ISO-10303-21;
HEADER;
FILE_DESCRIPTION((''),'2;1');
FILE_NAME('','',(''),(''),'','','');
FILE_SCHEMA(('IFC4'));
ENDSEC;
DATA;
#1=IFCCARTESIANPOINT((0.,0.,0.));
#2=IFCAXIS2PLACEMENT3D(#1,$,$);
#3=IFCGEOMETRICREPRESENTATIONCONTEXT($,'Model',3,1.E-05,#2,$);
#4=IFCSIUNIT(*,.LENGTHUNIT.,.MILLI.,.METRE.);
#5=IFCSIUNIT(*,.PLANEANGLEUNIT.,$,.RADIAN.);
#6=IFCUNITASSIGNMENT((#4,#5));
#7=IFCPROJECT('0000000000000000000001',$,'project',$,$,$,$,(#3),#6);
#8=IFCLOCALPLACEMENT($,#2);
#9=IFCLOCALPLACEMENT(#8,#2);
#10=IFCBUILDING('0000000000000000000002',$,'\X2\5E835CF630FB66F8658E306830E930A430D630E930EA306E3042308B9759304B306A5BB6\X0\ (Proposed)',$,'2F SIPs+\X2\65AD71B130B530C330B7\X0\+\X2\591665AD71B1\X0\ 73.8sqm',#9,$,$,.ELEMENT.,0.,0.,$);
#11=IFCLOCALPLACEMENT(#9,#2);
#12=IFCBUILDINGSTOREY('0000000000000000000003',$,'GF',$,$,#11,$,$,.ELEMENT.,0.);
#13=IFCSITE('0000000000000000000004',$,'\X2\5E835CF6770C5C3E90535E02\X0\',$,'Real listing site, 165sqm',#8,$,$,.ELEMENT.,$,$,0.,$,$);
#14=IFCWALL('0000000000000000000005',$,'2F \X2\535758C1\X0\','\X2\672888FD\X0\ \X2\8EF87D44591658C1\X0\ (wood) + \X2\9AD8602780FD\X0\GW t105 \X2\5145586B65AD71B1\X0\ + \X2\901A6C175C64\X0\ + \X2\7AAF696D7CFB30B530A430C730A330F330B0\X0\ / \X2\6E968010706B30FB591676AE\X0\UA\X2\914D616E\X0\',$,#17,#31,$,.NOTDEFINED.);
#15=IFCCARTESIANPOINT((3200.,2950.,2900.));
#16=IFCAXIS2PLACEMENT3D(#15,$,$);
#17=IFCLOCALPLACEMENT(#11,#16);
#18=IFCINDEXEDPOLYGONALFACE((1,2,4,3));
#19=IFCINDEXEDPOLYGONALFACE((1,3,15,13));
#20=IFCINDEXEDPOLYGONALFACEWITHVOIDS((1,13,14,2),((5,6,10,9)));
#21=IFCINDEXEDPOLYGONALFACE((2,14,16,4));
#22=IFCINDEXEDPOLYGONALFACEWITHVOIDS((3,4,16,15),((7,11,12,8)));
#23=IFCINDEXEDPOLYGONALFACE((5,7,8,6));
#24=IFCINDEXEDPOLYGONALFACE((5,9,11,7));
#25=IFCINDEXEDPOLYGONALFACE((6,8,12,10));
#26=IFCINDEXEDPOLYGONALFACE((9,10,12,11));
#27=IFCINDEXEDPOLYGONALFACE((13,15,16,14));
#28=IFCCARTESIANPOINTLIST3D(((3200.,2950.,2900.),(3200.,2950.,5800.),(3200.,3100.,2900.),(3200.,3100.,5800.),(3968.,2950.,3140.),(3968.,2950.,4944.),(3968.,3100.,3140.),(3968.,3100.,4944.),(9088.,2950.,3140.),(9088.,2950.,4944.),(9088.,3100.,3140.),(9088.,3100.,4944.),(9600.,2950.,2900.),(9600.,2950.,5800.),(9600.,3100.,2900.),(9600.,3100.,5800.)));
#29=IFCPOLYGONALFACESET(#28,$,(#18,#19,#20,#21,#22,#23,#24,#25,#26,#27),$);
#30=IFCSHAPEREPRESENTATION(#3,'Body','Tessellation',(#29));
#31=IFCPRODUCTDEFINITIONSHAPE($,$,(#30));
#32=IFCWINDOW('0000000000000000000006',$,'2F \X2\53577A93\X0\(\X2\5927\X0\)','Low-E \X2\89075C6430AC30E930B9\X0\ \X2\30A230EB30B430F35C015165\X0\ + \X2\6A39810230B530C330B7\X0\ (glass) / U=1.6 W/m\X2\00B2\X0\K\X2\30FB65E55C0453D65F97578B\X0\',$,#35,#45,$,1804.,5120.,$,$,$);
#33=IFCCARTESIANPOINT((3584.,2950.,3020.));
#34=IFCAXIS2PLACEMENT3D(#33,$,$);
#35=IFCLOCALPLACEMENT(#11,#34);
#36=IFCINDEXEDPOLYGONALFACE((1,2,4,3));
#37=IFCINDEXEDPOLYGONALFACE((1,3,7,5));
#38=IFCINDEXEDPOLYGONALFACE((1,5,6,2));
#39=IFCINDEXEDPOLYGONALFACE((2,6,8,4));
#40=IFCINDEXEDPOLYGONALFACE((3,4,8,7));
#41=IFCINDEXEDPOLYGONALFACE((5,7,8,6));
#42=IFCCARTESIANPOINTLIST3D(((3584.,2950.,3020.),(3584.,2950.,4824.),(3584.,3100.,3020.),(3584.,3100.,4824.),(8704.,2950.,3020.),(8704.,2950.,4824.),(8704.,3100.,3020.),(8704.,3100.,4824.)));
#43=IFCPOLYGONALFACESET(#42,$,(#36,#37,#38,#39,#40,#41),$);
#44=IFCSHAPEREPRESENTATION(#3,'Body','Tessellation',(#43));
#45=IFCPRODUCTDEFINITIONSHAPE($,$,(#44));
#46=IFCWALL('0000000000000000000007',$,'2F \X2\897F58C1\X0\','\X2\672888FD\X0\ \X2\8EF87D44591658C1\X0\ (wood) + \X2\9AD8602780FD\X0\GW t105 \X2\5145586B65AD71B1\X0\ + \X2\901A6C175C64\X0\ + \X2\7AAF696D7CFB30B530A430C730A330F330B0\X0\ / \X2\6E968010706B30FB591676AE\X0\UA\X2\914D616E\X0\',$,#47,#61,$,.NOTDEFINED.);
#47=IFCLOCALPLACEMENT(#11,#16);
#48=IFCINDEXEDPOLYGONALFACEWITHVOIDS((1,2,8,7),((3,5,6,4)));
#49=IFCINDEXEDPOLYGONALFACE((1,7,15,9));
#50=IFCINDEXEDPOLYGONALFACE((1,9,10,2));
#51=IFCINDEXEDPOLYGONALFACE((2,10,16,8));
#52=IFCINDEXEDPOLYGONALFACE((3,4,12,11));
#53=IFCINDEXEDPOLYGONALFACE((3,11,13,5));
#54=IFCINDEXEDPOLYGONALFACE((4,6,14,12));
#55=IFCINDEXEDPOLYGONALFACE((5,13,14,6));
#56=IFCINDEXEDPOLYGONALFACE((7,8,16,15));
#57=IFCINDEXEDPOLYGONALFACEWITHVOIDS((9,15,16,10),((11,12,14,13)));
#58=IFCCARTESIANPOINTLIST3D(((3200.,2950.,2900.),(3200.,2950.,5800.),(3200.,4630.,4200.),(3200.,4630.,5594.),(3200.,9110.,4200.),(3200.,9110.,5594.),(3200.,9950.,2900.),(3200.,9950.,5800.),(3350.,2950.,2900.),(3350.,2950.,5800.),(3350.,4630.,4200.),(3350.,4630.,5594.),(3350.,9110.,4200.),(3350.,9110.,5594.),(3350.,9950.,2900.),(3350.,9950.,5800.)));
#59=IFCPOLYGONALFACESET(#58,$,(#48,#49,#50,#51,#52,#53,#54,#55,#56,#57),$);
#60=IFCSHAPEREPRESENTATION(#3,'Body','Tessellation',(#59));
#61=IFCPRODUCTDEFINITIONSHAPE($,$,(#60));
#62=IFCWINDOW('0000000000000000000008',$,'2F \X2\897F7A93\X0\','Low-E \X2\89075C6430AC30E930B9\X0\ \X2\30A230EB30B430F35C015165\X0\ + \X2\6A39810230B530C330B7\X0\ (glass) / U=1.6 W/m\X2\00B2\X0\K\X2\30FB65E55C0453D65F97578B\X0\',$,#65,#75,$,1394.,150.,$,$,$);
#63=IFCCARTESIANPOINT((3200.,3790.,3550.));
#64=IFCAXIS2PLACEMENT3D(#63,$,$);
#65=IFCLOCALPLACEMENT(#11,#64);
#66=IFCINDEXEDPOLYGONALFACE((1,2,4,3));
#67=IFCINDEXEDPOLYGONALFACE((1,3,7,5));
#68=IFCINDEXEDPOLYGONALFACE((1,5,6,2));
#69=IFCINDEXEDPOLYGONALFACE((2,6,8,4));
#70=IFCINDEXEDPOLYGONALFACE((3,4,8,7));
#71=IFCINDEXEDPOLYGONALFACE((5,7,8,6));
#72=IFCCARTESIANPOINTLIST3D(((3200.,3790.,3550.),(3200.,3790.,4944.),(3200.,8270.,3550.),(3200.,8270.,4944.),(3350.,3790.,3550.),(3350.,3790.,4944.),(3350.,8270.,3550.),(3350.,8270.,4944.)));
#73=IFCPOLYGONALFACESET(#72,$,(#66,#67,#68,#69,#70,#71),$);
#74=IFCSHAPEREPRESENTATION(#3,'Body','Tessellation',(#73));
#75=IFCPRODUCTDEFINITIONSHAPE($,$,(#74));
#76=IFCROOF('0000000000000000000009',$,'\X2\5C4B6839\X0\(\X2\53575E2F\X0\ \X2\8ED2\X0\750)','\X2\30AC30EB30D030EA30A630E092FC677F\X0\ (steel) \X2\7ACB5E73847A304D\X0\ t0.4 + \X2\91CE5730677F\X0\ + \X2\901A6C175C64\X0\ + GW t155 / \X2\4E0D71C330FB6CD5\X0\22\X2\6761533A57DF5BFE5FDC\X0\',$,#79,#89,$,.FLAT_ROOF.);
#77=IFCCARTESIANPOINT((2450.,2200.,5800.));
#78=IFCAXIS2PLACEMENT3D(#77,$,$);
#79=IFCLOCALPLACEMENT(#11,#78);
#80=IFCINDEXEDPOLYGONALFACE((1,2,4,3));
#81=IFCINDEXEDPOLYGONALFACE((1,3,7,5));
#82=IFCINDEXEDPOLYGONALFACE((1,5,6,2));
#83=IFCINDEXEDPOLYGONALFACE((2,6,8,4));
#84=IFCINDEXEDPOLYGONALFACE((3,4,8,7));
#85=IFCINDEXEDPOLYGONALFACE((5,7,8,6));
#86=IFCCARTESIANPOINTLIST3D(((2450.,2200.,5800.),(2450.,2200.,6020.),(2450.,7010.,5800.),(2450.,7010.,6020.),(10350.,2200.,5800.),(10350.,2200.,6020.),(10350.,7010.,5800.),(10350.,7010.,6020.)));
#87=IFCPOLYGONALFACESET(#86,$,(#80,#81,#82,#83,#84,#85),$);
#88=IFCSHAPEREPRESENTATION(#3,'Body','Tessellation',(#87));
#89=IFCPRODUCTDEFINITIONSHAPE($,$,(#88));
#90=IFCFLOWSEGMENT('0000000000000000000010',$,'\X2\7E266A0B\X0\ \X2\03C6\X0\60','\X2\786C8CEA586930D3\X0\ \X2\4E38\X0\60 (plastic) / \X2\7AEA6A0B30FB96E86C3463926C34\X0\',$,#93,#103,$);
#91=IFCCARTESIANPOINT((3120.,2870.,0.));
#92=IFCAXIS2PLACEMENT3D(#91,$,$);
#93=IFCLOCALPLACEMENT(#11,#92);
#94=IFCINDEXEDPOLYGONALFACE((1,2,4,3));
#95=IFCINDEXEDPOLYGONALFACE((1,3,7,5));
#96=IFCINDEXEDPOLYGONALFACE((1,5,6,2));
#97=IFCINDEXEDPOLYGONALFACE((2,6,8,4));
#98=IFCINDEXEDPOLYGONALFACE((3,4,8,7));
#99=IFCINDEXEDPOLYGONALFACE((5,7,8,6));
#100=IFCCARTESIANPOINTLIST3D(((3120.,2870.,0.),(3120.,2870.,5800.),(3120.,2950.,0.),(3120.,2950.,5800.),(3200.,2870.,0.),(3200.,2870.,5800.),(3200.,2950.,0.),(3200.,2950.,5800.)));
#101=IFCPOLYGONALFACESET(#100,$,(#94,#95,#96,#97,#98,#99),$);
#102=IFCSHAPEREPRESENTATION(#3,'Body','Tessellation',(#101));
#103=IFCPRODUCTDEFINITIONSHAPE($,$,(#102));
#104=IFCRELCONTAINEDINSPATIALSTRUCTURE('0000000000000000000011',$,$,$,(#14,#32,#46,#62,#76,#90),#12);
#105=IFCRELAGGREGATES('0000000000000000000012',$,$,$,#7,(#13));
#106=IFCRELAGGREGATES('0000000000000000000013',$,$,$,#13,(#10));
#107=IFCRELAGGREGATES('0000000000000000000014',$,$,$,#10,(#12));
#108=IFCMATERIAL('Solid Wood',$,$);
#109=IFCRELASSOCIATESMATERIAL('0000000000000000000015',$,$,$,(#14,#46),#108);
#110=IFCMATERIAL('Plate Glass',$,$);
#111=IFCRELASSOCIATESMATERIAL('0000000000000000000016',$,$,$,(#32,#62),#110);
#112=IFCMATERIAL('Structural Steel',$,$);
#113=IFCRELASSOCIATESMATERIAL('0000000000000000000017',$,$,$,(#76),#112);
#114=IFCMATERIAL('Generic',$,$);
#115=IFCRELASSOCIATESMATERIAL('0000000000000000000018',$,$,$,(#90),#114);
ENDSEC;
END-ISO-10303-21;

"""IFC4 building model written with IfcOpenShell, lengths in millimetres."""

from ifc_helpers import new_model, si_unit, frame, frame_2d, origin, place, context, project, spatial, rectangle, extrude, material, element, fill, save


model = new_model("IFC4")

# Units and contexts
model_context = context("Model", 3, precision=1e-05, world=origin())
ifc_project = project(units=[si_unit("LENGTHUNIT", "METRE", prefix="MILLI"), si_unit("PLANEANGLEUNIT", "RADIAN")], contexts=[model_context])

# Site, building, storey
site_placement = place(None, origin())
site = spatial("IfcSite", under=ifc_project, at=site_placement, Name="広島県尾道市", ObjectType="Real listing site, 165sqm", CompositionType="ELEMENT", RefElevation=0.0)
building_placement = place(site_placement, origin())
building = spatial("IfcBuilding", under=site, at=building_placement, Name="広島・書斎とライブラリのある静かな家 (Proposed)", ObjectType="2F SIPs+断熱サッシ+外断熱 73.8sqm", CompositionType="ELEMENT", ElevationOfRefHeight=0.0, ElevationOfTerrain=0.0)
storey_placement = place(building_placement, origin())
storey = spatial("IfcBuildingStorey", under=building, at=storey_placement, Name="GF", CompositionType="ELEMENT", Elevation=0.0)

# Shared definitions
ifc_material_1 = material(Name="Solid Wood")

# Shared definitions
ifc_material_2 = material(Name="Plate Glass")

# Walls, openings, windows
wall_1_placement = place(storey_placement, frame((3200.0, 2950.0, 2900.0)))
wall_1 = element("IfcWall", 1, at=wall_1_placement, inside=storey, material=ifc_material_1, Name="2F 南壁", Description="木製 軸組外壁 (wood) + 高性能GW t105 充填断熱 + 通気層 + 窯業系サイディング / 準耐火・外皮UA配慮", PredefinedType="NOTDEFINED", context=model_context, shape_type="SweptSolid", body=[
    extrude(rectangle(XDim=6400.0, YDim=150.0, at=frame_2d((3200.0, 75.0))), frame((3200.0, 2950.0, 2900.0)), (0.0, 0.0, 1.0), 2900.0),
])
opening_1_placement = place(storey_placement, frame((3584.0, 2950.0, 3020.0)))
opening_1 = element("IfcOpeningElement", 2, at=opening_1_placement, cuts=wall_1, PredefinedType="NOTDEFINED", context=model_context, shape_type="SweptSolid", body=[
    extrude(rectangle(XDim=5120.0, YDim=150.0, at=frame_2d((2560.0, 75.0))), frame((3584.0, 2950.0, 3020.0)), (0.0, 0.0, 1.0), 1804.0),
])
window_1_placement = place(storey_placement, frame((3584.0, 2950.0, 3020.0)))
window_1 = element("IfcWindow", 3, at=window_1_placement, inside=storey, material=ifc_material_2, Name="2F 南窓(大)", Description="Low-E 複層ガラス アルゴン封入 + 樹脂サッシ (glass) / U=1.6 W/m²K・日射取得型", OverallHeight=1804.0, OverallWidth=5120.0, context=model_context, shape_type="SweptSolid", body=[
    extrude(rectangle(XDim=5120.0, YDim=150.0, at=frame_2d((2560.0, 75.0))), frame((3584.0, 2950.0, 3020.0)), (0.0, 0.0, 1.0), 1804.0),
])
fill(opening_1, window_1)
wall_2_placement = place(storey_placement, frame((3200.0, 2950.0, 2900.0)))
wall_2 = element("IfcWall", 4, at=wall_2_placement, inside=storey, material=ifc_material_1, Name="2F 西壁", Description="木製 軸組外壁 (wood) + 高性能GW t105 充填断熱 + 通気層 + 窯業系サイディング / 準耐火・外皮UA配慮", PredefinedType="NOTDEFINED", context=model_context, shape_type="SweptSolid", body=[
    extrude(rectangle(XDim=150.0, YDim=7000.0, at=frame_2d((75.0, 3500.0))), frame((3200.0, 2950.0, 2900.0)), (0.0, 0.0, 1.0), 2900.0),
])
opening_2_placement = place(storey_placement, frame((3200.0, 3790.0, 3550.0)))
opening_2 = element("IfcOpeningElement", 5, at=opening_2_placement, cuts=wall_2, PredefinedType="NOTDEFINED", context=model_context, shape_type="SweptSolid", body=[
    extrude(rectangle(XDim=150.0, YDim=4480.0, at=frame_2d((75.0, 2240.0))), frame((3200.0, 3790.0, 3550.0)), (0.0, 0.0, 1.0), 1394.0),
])
window_2_placement = place(storey_placement, frame((3200.0, 3790.0, 3550.0)))
window_2 = element("IfcWindow", 6, at=window_2_placement, inside=storey, material=ifc_material_2, Name="2F 西窓", Description="Low-E 複層ガラス アルゴン封入 + 樹脂サッシ (glass) / U=1.6 W/m²K・日射取得型", OverallHeight=1394.0, OverallWidth=150.0, context=model_context, shape_type="SweptSolid", body=[
    extrude(rectangle(XDim=150.0, YDim=4480.0, at=frame_2d((75.0, 2240.0))), frame((3200.0, 3790.0, 3550.0)), (0.0, 0.0, 1.0), 1394.0),
])
fill(opening_2, window_2)

# Roof
ifc_material_3 = material(Name="Structural Steel")
for number, where, name in (
    (7, (2450.0, 2200.0, 5800.0), "屋根(南帯 軒750)"),
):
    element("IfcRoof", number, at=place(storey_placement, frame(where)), inside=storey, material=ifc_material_3, Name=name, Description="ガルバリウム鋼板 (steel) 立平葺き t0.4 + 野地板 + 通気層 + GW t155 / 不燃・法22条区域対応", PredefinedType="FLAT_ROOF", context=model_context, shape_type="SweptSolid", body=[
        extrude(rectangle(XDim=7900.0, YDim=4810.0, at=frame_2d((3950.0, 2405.0))), frame((2450.0, 2200.0, 5800.0)), (0.0, 0.0, 1.0), 220.0),
    ])

# Flow segment
ifc_material_4 = material(Name="Generic")
flow_segment_1_placement = place(storey_placement, frame((3120.0, 2870.0, 0.0)))
element("IfcFlowSegment", 8, at=flow_segment_1_placement, inside=storey, material=ifc_material_4, Name="縦樋 φ60", Description="硬質塩ビ 丸60 (plastic) / 竪樋・雨水排水", context=model_context, shape_type="SweptSolid", body=[
    extrude(rectangle(XDim=80.0, YDim=80.0, at=frame_2d((40.0, 40.0))), frame((3120.0, 2870.0, 0.0)), (0.0, 0.0, 1.0), 5800.0),
])

save(model, "model.ifc")
